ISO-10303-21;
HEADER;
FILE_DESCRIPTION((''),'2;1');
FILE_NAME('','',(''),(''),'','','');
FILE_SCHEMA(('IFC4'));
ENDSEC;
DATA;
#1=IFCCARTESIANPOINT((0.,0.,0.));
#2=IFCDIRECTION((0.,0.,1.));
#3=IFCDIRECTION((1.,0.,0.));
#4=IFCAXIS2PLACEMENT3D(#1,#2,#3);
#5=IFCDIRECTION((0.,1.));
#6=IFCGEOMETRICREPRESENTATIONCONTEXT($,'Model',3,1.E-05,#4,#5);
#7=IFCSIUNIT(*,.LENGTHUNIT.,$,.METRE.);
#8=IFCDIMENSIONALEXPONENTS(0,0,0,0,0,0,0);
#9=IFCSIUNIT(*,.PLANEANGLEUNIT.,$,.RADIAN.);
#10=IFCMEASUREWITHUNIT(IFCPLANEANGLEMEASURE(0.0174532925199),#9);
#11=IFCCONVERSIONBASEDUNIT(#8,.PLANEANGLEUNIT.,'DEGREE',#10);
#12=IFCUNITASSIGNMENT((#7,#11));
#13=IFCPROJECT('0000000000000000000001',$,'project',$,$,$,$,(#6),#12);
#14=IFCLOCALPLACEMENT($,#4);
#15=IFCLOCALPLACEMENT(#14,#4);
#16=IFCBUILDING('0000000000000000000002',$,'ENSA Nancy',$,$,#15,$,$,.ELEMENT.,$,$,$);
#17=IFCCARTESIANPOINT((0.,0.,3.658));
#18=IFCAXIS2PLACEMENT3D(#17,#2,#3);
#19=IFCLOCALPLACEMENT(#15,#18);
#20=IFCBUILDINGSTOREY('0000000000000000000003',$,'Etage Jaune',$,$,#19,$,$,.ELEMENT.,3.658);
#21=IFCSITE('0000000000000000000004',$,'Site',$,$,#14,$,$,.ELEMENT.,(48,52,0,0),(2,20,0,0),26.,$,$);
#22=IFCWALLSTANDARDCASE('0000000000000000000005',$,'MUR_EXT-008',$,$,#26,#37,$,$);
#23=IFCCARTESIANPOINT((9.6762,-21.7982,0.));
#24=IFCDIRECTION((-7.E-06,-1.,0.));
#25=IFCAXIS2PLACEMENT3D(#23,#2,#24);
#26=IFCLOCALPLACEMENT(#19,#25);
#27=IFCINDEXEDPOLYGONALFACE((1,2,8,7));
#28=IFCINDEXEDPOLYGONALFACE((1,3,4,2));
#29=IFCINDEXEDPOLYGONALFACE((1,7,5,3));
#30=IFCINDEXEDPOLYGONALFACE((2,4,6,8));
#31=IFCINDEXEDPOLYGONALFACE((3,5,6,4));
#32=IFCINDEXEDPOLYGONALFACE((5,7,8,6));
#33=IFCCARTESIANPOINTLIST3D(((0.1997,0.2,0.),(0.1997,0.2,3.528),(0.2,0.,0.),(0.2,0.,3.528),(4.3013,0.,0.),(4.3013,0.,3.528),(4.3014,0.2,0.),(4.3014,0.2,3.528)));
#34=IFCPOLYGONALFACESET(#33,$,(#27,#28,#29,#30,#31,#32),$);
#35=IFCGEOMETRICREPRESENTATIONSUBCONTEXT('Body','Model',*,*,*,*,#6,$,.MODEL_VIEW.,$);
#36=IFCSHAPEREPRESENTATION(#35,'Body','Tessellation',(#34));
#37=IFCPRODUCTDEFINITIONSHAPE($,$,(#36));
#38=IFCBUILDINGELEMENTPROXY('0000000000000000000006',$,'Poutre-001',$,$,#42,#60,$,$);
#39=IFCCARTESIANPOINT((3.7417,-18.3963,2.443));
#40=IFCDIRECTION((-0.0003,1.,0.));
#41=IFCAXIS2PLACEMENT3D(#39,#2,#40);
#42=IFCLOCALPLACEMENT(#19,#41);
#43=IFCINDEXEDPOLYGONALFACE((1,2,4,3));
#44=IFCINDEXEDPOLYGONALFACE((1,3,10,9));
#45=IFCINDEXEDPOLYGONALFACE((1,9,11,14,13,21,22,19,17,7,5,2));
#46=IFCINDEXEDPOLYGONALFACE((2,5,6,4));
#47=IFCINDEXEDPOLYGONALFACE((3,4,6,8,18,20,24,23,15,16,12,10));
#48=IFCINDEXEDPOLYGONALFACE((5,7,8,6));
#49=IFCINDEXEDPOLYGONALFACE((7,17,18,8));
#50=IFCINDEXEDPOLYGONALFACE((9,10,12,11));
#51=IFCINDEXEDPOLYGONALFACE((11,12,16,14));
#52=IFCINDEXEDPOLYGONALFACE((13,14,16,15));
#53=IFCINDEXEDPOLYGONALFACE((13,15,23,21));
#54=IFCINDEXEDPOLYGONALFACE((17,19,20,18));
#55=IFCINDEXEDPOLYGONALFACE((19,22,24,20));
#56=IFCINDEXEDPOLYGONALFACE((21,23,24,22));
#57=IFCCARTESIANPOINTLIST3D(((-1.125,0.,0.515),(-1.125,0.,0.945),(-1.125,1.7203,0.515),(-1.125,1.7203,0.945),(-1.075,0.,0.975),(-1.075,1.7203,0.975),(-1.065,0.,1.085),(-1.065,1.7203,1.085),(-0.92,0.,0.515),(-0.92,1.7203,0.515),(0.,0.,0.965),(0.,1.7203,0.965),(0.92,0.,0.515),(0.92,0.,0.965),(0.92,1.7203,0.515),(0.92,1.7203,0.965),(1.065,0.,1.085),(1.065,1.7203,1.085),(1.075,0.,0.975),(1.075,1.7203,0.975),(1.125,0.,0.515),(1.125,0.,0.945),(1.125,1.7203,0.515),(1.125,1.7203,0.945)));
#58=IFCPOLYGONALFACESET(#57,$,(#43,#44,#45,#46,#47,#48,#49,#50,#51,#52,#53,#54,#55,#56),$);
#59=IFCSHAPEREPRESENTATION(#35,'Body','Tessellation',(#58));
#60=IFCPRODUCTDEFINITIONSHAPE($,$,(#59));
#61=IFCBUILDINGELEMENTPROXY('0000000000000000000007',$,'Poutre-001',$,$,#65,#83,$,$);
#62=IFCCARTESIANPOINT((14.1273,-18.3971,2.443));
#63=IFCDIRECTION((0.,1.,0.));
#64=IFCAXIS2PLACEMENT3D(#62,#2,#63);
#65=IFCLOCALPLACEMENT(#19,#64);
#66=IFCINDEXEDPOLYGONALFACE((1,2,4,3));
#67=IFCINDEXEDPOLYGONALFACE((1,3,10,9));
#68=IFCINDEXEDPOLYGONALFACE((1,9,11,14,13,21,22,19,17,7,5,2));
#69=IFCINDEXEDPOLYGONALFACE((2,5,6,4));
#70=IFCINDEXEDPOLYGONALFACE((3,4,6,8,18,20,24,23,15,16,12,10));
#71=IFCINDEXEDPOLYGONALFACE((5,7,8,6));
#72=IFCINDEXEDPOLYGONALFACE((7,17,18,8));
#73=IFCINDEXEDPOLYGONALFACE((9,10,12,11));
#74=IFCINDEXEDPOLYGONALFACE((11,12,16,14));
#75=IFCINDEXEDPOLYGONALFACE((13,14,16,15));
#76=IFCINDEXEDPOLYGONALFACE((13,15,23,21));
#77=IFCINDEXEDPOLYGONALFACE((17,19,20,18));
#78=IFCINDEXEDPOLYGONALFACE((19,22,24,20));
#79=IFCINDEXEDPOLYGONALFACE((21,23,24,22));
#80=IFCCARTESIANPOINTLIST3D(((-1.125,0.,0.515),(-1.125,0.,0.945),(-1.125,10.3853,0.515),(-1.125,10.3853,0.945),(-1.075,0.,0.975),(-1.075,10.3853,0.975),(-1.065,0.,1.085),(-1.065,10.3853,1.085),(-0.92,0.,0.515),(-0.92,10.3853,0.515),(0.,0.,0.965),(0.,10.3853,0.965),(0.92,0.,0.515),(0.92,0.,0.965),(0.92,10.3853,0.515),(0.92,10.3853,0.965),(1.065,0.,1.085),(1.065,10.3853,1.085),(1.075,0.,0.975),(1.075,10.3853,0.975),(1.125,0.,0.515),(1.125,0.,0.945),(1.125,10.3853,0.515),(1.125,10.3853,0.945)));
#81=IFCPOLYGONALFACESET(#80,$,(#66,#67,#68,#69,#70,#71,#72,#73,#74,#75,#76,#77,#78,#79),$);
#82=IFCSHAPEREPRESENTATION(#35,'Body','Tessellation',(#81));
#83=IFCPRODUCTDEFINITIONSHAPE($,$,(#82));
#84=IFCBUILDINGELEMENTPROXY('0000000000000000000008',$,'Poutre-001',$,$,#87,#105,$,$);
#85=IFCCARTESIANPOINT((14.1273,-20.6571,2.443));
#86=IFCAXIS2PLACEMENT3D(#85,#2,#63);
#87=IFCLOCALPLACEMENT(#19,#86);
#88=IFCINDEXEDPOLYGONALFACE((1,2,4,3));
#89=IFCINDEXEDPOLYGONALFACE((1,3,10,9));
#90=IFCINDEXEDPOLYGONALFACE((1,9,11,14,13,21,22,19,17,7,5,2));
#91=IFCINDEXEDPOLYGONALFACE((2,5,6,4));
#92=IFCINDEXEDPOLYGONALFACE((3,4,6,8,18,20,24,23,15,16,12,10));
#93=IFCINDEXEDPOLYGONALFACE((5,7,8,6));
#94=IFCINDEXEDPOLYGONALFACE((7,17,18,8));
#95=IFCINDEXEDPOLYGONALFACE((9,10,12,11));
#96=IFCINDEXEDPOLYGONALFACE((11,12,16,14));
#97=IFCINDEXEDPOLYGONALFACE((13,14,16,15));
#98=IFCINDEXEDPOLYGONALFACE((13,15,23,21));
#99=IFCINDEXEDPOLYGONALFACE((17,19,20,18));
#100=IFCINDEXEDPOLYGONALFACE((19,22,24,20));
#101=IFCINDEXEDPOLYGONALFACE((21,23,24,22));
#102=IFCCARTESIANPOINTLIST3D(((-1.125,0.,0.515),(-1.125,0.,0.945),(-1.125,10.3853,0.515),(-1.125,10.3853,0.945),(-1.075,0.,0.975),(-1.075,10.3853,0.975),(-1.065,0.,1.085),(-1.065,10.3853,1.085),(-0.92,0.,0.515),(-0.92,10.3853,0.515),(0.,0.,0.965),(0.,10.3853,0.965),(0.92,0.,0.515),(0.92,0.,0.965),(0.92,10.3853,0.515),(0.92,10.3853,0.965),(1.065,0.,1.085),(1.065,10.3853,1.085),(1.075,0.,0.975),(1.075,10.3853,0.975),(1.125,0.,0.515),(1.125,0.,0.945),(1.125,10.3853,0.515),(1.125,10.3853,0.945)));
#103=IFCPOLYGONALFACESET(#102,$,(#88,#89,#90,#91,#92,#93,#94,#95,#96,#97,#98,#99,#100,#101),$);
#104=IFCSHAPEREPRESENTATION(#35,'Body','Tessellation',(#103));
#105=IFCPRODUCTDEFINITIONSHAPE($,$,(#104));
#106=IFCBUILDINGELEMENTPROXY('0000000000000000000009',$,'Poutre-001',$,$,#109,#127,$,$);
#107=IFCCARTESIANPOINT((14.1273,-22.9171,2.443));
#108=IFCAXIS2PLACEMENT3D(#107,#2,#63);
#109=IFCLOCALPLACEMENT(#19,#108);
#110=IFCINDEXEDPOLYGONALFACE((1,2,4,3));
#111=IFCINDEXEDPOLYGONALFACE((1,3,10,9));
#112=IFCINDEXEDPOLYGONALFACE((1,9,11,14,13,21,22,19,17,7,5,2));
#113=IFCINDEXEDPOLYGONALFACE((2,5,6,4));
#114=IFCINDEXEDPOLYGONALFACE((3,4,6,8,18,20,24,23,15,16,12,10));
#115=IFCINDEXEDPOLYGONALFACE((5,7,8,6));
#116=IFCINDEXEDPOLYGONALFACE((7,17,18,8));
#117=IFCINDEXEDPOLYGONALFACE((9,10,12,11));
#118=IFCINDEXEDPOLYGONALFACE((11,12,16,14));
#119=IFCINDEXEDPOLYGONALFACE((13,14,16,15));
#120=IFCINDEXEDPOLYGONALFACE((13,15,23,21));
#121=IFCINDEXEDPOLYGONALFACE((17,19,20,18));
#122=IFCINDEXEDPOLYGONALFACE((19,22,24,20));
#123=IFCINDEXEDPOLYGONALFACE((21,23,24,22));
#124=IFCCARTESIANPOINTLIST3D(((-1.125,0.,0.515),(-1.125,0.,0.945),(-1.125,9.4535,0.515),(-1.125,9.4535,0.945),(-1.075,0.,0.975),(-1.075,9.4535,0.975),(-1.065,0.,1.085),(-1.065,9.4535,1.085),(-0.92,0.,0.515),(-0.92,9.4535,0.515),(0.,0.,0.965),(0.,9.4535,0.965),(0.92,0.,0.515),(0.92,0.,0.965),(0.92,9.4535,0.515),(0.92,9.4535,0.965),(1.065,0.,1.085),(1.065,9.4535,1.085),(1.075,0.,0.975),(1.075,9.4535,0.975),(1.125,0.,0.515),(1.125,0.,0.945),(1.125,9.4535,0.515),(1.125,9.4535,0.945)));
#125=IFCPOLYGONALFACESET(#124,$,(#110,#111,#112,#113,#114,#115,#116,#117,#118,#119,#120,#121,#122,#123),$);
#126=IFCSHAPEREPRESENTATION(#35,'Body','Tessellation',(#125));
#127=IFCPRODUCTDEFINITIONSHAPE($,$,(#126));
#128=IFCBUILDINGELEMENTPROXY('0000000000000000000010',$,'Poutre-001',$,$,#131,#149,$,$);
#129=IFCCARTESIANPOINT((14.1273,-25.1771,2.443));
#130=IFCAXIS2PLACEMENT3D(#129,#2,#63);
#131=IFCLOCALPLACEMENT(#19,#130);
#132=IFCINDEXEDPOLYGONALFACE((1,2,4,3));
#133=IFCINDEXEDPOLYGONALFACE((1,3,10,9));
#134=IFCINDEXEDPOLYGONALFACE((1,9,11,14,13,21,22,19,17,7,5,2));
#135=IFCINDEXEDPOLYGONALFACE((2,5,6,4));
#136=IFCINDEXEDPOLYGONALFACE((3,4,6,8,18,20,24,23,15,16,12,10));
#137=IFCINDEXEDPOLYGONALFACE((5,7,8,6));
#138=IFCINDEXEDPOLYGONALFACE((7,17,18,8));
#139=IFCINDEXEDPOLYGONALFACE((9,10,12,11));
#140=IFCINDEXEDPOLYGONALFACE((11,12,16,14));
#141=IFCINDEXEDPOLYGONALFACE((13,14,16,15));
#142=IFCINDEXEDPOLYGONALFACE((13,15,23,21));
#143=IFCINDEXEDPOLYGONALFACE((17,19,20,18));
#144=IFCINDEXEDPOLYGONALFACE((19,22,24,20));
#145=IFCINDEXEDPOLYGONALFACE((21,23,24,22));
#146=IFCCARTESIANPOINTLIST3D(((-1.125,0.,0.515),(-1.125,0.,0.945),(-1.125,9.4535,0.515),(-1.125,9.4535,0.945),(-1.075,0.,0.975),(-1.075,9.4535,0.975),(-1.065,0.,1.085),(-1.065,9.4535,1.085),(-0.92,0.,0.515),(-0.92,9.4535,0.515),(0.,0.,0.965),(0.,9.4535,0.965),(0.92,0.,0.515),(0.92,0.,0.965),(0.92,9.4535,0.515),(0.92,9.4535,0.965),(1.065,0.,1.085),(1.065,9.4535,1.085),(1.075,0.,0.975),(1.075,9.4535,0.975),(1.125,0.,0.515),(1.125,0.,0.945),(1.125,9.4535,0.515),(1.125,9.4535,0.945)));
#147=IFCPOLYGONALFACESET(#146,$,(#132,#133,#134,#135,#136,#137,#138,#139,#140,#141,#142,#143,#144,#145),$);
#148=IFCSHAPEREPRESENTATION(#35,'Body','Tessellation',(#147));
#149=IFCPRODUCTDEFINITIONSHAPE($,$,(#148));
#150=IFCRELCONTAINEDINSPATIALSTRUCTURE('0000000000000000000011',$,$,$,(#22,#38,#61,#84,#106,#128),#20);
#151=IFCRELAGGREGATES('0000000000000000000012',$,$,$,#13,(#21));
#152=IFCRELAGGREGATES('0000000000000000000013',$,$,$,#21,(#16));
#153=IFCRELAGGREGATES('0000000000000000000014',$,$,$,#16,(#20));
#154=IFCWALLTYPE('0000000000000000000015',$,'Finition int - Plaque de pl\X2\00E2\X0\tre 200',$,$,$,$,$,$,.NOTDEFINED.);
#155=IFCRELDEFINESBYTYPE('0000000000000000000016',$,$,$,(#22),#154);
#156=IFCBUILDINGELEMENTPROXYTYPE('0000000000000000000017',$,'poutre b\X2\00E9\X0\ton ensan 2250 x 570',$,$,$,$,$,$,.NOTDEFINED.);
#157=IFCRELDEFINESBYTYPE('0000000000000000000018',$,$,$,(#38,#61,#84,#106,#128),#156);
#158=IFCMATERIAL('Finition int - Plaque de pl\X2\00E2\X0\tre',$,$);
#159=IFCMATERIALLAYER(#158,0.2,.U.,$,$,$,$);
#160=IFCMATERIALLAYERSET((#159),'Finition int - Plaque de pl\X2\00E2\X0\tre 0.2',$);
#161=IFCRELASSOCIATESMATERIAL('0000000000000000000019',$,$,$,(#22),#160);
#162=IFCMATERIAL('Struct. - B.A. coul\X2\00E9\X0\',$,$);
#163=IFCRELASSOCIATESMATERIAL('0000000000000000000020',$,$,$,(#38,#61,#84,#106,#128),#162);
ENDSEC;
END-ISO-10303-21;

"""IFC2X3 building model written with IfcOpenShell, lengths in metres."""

from ifc_helpers import new_model, entity, si_unit, converted_unit, direction, frame, origin_with_axes, place, context, subcontext, project, spatial, polyline, outline, extrude, material, layer, layer_set, layer_usage, type_object, element, save


model = new_model("IFC2X3")

# Units and contexts
model_context = context("Model", 3, precision=1e-05, world=origin_with_axes(), true_north=direction((0.0, 1.0)))
body_context = subcontext(model_context, "Body", "Model", "MODEL_VIEW")
ifc_project = project(units=[si_unit("LENGTHUNIT", "METRE"), converted_unit("PLANEANGLEUNIT", "DEGREE", entity("IfcPlaneAngleMeasure", 0.0174532925199), si_unit("PLANEANGLEUNIT", "RADIAN"), dimensions=[0, 0, 0, 0, 0, 0, 0])], contexts=[model_context])

# Site, building, storey
site_placement = place(None, origin_with_axes())
site = spatial("IfcSite", under=ifc_project, at=site_placement, Name="Site", CompositionType="ELEMENT", RefLatitude=(48, 52, 0, 0), RefLongitude=(2, 20, 0, 0), RefElevation=26.0)
building_placement = place(site_placement, origin_with_axes())
building = spatial("IfcBuilding", under=site, at=building_placement, Name="ENSA Nancy", CompositionType="ELEMENT")
storey_placement = place(building_placement, frame((0.0, 0.0, 3.658), z_axis=(0.0, 0.0, 1.0), x_axis=(1.0, 0.0, 0.0)))
storey = spatial("IfcBuildingStorey", under=building, at=storey_placement, Name="Etage Jaune", CompositionType="ELEMENT", Elevation=3.658)

# Shared definitions
ifc_material_1 = material(Name="Finition int - Plaque de plâtre")
ifc_layer_1 = layer(ifc_material_1, 0.2, ventilated="UNKNOWN")
ifc_layer_set_1 = layer_set([ifc_layer_1], Name="Finition int - Plaque de plâtre 0.2")
wall_type_1 = type_object("IfcWallType", Name="Finition int - Plaque de plâtre 200", PredefinedType="NOTDEFINED")

# Wall
ifc_layer_usage_1 = layer_usage(ifc_layer_set_1, "AXIS2", "POSITIVE", 0.0)
wall_1_placement = place(storey_placement, frame((9.6762, -21.7982, 0.0), z_axis=(0.0, 0.0, 1.0), x_axis=(-0.000007, -1.0, 0.0)))
element("IfcWallStandardCase", 1, at=wall_1_placement, inside=storey, type_object=wall_type_1, material=ifc_layer_usage_1, Name="MUR_EXT-008", context=body_context, shape_type="SweptSolid", body=[
    extrude(outline(polyline([(0.2, 0.0), (4.3013, 0.0), (4.3014, 0.2), (0.1997, 0.2), (0.2, 0.0)])), origin_with_axes(), (0.0, 0.0, 1.0), 3.528),
])

# Building element proxies
ifc_material_2 = material(Name="Struct. - B.A. coulé")
building_element_proxy_type_1 = type_object("IfcBuildingElementProxyType", Name="poutre béton ensan 2250 x 570", PredefinedType="NOTDEFINED")
proxy_1_placement = place(storey_placement, frame((3.7417, -18.3963, 2.443), z_axis=(0.0, 0.0, 1.0), x_axis=(-0.0003, 1.0, 0.0)))
element("IfcBuildingElementProxy", 2, at=proxy_1_placement, inside=storey, type_object=building_element_proxy_type_1, material=ifc_material_2, Name="Poutre-001", context=body_context, shape_type="SweptSolid", body=[
    extrude(outline(polyline([(-1.065, 1.085), (-1.075, 0.975), (-1.125, 0.945), (-1.125, 0.515), (-0.92, 0.515), (0.0, 0.965), (0.92, 0.965), (0.92, 0.515), (1.125, 0.515), (1.125, 0.945), (1.075, 0.975), (1.065, 1.085), (-1.065, 1.085)])), frame((0.0, 1.7203, 0.0), z_axis=(0.0, -1.0, 0.0), x_axis=(1.0, 0.0, 0.0)), (0.0, 0.0, 1.0), 1.7203),
])
for number, where, z_axis, x_axis, name in (
    (3, (14.1273, -18.3971, 2.443), (0.0, 0.0, 1.0), (0.0, 1.0, 0.0), "Poutre-001"),
    (4, (14.1273, -20.6571, 2.443), (0.0, 0.0, 1.0), (0.0, 1.0, 0.0), "Poutre-001"),
):
    element("IfcBuildingElementProxy", number, at=place(storey_placement, frame(where, z_axis=z_axis, x_axis=x_axis)), inside=storey, type_object=building_element_proxy_type_1, material=ifc_material_2, Name=name, context=body_context, shape_type="SweptSolid", body=[
        extrude(outline(polyline([(-1.065, 1.085), (-1.075, 0.975), (-1.125, 0.945), (-1.125, 0.515), (-0.92, 0.515), (0.0, 0.965), (0.92, 0.965), (0.92, 0.515), (1.125, 0.515), (1.125, 0.945), (1.075, 0.975), (1.065, 1.085), (-1.065, 1.085)])), frame((0.0, 10.3853, 0.0), z_axis=(0.0, -1.0, 0.0), x_axis=(1.0, 0.0, 0.0)), (0.0, 0.0, 1.0), 10.3853),
    ])
for number, where, z_axis, x_axis, name in (
    (5, (14.1273, -22.9171, 2.443), (0.0, 0.0, 1.0), (0.0, 1.0, 0.0), "Poutre-001"),
    (6, (14.1273, -25.1771, 2.443), (0.0, 0.0, 1.0), (0.0, 1.0, 0.0), "Poutre-001"),
):
    element("IfcBuildingElementProxy", number, at=place(storey_placement, frame(where, z_axis=z_axis, x_axis=x_axis)), inside=storey, type_object=building_element_proxy_type_1, material=ifc_material_2, Name=name, context=body_context, shape_type="SweptSolid", body=[
        extrude(outline(polyline([(-1.065, 1.085), (-1.075, 0.975), (-1.125, 0.945), (-1.125, 0.515), (-0.92, 0.515), (0.0, 0.965), (0.92, 0.965), (0.92, 0.515), (1.125, 0.515), (1.125, 0.945), (1.075, 0.975), (1.065, 1.085), (-1.065, 1.085)])), frame((0.0, 9.4535, 0.0), z_axis=(0.0, -1.0, 0.0), x_axis=(1.0, 0.0, 0.0)), (0.0, 0.0, 1.0), 9.4535),
    ])

save(model, "model.ifc")
